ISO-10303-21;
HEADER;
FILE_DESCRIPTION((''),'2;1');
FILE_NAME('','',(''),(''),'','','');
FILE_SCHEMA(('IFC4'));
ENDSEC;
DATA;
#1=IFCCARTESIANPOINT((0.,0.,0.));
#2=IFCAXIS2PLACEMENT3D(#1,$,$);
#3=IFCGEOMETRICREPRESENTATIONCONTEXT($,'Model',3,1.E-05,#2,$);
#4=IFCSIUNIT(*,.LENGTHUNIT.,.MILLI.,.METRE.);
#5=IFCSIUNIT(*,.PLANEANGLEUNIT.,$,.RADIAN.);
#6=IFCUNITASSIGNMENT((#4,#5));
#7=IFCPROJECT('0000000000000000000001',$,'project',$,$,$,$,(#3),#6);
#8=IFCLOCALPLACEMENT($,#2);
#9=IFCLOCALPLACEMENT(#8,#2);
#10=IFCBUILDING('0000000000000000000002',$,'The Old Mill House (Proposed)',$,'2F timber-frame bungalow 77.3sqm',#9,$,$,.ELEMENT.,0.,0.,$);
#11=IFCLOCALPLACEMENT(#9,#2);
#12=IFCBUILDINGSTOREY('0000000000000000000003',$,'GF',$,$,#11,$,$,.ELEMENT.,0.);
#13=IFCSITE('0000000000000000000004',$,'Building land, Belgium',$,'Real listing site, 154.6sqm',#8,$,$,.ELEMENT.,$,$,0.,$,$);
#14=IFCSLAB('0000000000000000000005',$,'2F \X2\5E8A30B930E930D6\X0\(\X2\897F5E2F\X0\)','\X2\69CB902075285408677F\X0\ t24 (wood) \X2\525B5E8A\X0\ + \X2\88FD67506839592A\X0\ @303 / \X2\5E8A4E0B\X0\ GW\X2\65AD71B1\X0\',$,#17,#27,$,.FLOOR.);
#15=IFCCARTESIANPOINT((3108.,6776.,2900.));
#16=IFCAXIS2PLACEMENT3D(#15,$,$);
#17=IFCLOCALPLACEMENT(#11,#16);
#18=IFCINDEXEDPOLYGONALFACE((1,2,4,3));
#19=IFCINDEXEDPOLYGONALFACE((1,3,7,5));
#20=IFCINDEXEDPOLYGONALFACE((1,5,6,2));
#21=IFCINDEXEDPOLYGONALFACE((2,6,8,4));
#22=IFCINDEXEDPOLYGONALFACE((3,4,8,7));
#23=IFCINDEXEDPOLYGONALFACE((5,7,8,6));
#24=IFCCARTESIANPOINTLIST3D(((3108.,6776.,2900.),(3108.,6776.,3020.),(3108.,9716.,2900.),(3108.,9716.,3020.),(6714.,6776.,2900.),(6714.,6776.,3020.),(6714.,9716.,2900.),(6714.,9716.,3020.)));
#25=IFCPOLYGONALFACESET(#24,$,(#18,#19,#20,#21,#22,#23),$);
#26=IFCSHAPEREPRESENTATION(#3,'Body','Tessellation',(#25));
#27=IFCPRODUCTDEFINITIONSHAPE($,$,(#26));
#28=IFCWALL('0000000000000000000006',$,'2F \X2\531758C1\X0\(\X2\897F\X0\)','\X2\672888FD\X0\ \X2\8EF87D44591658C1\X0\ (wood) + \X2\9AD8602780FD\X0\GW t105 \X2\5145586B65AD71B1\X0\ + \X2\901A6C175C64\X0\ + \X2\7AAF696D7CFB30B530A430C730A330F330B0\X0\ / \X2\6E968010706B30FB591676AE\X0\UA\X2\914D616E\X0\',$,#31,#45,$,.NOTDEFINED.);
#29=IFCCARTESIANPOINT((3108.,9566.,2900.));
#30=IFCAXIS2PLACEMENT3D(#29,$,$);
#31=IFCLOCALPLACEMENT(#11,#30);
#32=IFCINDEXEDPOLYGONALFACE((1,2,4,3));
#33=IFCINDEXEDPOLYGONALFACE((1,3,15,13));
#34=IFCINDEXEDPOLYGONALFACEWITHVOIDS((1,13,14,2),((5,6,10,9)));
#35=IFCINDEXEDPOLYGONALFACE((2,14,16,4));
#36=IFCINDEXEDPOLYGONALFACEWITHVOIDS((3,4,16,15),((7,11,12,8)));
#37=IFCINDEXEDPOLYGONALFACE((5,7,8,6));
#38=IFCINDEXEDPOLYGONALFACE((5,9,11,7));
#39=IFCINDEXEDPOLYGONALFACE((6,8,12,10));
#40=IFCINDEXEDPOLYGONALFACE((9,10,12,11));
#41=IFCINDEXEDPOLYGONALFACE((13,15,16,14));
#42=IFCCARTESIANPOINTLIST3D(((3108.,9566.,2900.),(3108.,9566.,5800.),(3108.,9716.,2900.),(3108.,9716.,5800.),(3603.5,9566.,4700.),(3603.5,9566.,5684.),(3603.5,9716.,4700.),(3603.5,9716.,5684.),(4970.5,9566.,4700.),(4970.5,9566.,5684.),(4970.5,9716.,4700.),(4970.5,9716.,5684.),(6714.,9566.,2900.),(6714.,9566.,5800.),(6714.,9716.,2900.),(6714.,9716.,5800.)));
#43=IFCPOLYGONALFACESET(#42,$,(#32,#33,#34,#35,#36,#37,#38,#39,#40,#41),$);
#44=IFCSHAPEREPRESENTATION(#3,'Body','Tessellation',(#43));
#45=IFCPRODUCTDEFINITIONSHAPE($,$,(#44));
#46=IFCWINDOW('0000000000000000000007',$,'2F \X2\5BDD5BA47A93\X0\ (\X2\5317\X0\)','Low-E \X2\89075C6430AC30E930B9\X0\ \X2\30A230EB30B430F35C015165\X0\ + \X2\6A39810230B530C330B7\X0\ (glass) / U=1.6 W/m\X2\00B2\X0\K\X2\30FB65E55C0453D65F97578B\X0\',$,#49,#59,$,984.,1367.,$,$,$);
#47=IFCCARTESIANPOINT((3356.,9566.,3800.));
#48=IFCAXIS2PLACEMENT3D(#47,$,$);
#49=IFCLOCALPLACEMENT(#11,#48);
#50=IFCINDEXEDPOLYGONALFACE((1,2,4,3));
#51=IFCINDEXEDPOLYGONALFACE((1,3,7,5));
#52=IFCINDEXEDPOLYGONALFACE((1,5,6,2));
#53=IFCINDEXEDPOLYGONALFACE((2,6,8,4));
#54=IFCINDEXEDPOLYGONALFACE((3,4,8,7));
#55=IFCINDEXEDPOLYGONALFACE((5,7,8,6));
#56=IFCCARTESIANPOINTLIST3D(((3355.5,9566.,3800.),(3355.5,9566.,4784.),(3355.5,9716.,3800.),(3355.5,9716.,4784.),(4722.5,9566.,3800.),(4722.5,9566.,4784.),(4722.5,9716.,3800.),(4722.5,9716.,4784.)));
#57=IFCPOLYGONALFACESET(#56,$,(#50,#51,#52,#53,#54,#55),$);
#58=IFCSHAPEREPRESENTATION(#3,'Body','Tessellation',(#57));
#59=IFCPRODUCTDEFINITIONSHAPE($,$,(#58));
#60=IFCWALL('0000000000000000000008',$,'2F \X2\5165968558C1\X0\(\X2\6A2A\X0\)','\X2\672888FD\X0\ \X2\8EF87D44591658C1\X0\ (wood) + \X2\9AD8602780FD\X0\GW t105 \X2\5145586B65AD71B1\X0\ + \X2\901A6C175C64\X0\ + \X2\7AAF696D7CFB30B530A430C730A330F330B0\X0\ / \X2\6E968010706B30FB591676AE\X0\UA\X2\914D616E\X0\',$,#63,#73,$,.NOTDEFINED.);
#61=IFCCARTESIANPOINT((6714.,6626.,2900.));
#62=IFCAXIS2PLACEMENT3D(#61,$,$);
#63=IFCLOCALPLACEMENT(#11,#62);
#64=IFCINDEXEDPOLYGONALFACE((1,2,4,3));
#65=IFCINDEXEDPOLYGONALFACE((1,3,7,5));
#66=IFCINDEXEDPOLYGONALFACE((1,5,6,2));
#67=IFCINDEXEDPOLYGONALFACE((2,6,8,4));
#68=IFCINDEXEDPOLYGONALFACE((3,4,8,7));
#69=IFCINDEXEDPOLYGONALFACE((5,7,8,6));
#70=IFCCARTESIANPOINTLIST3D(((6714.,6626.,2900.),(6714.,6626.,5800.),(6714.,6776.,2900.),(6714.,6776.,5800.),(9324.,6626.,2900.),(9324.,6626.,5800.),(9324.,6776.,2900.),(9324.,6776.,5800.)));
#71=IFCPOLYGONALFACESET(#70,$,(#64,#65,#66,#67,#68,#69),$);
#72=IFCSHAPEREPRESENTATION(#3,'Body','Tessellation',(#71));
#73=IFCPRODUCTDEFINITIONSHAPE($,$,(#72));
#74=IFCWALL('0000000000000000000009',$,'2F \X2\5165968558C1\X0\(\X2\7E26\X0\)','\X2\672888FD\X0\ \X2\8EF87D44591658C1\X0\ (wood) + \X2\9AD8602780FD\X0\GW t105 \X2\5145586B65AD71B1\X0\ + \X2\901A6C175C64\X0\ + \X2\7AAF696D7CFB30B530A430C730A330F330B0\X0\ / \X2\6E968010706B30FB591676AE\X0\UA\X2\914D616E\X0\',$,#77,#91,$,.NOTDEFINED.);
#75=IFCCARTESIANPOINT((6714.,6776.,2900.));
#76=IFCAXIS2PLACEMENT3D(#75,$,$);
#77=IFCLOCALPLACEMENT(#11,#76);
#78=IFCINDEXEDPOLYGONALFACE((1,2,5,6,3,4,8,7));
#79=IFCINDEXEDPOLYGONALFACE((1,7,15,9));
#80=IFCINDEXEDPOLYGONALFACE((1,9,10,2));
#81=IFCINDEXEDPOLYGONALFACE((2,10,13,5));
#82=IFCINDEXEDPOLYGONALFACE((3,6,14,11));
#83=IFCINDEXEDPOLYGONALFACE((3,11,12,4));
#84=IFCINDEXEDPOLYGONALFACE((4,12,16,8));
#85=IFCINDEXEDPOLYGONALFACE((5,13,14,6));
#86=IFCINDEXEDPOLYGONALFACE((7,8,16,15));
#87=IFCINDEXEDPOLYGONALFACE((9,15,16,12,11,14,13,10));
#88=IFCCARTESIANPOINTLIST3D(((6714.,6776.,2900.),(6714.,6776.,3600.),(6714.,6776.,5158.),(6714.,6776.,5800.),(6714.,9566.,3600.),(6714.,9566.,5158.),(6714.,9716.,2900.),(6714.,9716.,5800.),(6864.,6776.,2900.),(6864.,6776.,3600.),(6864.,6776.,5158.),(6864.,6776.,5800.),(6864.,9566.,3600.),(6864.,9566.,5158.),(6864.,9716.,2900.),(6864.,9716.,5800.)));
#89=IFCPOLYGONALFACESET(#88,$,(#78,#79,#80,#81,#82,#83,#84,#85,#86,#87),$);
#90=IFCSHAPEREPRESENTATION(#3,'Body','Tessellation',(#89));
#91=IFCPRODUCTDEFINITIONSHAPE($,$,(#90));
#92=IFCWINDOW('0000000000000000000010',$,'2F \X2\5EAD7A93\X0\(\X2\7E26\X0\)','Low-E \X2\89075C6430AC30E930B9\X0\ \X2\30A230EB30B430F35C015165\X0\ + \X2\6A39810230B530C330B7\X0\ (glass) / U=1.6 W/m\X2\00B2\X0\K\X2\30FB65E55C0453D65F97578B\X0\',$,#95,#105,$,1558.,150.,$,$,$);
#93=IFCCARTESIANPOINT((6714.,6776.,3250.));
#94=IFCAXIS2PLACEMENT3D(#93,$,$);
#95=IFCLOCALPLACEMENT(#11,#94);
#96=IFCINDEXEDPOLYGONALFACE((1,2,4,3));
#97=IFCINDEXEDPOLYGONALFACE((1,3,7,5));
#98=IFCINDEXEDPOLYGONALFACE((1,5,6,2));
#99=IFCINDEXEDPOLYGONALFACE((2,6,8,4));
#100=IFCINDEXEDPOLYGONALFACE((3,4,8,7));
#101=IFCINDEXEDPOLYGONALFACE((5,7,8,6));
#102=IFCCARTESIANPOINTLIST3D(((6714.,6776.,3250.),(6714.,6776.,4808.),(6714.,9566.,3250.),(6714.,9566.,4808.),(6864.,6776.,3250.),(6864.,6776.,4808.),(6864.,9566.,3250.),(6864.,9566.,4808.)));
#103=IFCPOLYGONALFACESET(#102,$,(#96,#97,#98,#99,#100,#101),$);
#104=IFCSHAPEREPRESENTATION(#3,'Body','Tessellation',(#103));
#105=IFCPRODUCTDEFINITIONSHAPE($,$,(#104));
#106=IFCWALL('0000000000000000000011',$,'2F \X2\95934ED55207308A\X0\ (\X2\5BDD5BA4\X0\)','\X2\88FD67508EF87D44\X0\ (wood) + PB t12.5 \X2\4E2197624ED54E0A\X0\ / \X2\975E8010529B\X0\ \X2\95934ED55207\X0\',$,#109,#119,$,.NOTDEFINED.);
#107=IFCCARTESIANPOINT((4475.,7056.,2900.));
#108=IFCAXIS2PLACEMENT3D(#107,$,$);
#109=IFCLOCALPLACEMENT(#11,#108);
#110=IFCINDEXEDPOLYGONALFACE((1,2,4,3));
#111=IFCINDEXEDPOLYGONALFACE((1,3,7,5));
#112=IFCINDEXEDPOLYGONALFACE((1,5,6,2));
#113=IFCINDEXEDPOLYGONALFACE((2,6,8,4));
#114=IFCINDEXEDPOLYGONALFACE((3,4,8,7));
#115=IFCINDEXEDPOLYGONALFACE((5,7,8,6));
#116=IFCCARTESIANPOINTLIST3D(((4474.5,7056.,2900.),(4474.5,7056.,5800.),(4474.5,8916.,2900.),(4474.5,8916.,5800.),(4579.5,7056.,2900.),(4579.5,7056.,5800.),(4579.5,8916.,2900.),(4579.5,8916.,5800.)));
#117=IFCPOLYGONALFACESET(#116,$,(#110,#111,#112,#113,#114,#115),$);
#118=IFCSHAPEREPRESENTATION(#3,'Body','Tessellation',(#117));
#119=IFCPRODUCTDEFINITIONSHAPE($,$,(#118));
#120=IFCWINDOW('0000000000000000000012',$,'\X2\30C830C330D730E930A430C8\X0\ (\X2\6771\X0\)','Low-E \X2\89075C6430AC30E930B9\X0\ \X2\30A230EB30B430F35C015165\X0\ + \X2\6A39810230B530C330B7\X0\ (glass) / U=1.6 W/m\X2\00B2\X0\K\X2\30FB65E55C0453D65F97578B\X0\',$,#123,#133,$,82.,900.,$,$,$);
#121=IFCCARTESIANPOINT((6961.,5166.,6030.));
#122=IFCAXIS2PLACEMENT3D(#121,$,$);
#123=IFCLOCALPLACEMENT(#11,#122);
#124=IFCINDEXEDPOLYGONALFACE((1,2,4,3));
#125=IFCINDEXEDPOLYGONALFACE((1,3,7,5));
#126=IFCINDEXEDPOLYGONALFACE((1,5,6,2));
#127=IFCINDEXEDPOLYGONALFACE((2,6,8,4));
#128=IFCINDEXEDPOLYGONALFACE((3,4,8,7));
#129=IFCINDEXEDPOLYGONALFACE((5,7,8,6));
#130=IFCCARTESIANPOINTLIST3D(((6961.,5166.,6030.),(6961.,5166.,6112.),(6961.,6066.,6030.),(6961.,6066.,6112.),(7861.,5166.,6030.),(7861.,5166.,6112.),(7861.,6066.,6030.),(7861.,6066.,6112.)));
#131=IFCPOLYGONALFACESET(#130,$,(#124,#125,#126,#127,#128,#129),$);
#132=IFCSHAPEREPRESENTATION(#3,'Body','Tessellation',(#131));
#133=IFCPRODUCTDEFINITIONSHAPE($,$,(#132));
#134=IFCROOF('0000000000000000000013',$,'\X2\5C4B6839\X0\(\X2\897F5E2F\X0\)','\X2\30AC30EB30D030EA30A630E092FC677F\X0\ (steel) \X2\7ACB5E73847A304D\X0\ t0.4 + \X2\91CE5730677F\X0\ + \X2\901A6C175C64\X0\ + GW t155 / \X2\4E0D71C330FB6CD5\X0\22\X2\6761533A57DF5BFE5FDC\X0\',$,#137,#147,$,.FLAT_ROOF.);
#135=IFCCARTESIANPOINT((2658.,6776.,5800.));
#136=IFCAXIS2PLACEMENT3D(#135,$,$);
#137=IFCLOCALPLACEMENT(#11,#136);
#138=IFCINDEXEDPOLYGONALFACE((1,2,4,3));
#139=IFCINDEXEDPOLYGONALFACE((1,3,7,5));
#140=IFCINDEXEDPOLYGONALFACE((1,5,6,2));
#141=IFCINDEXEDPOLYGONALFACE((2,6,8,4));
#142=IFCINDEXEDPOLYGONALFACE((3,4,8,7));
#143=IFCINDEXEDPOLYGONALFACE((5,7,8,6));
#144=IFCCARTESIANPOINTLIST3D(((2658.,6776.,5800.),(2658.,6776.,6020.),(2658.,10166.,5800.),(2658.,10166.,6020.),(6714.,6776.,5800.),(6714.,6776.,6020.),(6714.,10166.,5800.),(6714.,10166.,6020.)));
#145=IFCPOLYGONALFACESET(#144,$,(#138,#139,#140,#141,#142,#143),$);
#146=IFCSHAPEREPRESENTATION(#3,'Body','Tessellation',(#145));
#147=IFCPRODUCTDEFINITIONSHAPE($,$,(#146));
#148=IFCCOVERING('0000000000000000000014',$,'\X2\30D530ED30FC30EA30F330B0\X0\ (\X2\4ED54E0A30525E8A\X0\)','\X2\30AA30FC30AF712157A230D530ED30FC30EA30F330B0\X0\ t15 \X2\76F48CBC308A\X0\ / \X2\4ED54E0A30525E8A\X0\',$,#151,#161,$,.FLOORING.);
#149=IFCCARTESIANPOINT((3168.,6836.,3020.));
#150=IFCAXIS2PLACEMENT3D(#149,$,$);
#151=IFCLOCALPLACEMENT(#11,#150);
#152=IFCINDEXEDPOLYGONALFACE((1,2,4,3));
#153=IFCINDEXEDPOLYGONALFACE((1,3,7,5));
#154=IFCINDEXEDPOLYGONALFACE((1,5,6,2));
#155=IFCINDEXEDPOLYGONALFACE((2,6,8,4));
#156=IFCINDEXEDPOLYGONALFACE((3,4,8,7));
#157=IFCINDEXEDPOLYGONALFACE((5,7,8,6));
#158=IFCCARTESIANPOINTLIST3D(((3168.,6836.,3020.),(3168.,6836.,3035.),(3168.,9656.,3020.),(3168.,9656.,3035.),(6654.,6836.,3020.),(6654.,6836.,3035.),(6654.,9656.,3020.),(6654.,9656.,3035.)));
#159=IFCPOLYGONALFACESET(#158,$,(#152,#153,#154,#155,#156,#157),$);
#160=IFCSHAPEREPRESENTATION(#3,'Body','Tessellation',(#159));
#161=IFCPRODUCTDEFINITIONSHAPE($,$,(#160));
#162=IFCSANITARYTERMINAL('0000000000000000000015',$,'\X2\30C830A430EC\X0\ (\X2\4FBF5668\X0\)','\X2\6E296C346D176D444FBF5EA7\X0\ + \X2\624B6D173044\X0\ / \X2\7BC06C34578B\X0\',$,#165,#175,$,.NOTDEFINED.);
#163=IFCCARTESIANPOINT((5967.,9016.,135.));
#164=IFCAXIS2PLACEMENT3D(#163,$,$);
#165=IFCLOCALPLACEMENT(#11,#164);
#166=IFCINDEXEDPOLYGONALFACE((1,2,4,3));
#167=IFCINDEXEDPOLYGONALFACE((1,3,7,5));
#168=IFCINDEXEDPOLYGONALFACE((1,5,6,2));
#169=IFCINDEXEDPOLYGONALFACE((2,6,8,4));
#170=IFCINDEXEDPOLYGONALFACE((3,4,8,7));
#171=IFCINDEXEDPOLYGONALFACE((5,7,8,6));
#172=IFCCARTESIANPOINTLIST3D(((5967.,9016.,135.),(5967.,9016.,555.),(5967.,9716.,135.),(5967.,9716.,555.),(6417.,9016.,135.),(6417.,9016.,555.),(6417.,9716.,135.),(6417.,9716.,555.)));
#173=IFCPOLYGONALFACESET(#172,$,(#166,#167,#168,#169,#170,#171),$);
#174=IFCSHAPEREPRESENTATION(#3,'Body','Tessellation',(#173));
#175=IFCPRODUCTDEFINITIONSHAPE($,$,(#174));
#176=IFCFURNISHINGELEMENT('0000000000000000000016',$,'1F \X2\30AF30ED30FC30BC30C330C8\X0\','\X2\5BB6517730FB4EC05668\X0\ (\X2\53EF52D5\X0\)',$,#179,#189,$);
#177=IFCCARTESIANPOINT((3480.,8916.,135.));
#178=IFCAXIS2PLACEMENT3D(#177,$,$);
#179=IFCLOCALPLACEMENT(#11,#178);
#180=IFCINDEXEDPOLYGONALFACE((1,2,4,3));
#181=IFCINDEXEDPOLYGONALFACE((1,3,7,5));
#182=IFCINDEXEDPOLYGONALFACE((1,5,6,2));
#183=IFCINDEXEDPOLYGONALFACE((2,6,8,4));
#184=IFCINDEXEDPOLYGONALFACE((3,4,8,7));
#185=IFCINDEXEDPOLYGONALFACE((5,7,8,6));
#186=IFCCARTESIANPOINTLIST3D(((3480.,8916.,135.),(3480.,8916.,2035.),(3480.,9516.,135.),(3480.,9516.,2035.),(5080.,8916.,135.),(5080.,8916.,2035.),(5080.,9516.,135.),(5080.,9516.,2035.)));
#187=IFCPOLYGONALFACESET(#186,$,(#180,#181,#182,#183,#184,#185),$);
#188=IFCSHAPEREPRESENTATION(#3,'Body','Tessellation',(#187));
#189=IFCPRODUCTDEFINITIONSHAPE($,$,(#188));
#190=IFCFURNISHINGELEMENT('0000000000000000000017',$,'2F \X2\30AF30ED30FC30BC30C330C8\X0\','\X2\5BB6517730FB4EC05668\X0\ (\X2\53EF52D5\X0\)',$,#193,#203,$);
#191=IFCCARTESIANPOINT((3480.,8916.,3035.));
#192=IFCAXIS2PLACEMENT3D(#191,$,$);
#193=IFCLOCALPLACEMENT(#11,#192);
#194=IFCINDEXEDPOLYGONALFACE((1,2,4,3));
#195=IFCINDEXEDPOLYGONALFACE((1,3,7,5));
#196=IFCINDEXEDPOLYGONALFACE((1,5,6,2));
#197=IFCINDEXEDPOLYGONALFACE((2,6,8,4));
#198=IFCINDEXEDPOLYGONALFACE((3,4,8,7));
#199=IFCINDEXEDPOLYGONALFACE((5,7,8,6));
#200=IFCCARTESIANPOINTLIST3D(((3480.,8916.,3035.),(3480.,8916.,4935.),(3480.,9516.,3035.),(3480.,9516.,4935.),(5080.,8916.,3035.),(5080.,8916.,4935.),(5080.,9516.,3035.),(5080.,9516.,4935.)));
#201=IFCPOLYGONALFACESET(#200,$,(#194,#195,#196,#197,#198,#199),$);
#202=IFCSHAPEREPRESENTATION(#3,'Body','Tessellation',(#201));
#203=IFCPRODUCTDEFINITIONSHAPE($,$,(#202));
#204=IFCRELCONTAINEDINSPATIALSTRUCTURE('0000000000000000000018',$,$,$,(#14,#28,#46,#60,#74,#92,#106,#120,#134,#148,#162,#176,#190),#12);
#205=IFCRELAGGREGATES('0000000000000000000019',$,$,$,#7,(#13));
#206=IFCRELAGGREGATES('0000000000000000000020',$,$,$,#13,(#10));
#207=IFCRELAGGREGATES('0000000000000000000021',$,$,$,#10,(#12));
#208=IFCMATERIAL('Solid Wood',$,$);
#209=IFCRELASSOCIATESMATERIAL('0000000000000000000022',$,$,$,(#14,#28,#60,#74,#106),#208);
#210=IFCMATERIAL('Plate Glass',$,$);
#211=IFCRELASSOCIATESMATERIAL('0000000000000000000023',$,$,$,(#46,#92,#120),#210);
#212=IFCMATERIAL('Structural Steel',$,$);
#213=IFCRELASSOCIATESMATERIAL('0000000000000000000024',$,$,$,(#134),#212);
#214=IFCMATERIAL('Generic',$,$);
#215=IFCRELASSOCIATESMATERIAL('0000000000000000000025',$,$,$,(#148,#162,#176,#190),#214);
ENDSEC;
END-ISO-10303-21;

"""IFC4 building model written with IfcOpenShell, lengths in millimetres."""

from ifc_helpers import new_model, si_unit, frame, frame_2d, origin, place, context, project, spatial, rectangle, extrude, material, element, fill, save


model = new_model("IFC4")

# Units and contexts
model_context = context("Model", 3, precision=1e-05, world=origin())
ifc_project = project(units=[si_unit("LENGTHUNIT", "METRE", prefix="MILLI"), si_unit("PLANEANGLEUNIT", "RADIAN")], contexts=[model_context])

# Site, building, storey
site_placement = place(None, origin())
site = spatial("IfcSite", under=ifc_project, at=site_placement, Name="Building land, Belgium", ObjectType="Real listing site, 154.6sqm", CompositionType="ELEMENT", RefElevation=0.0)
building_placement = place(site_placement, origin())
building = spatial("IfcBuilding", under=site, at=building_placement, Name="The Old Mill House (Proposed)", ObjectType="2F timber-frame bungalow 77.3sqm", CompositionType="ELEMENT", ElevationOfRefHeight=0.0, ElevationOfTerrain=0.0)
storey_placement = place(building_placement, origin())
storey = spatial("IfcBuildingStorey", under=building, at=storey_placement, Name="GF", CompositionType="ELEMENT", Elevation=0.0)

# Slab
ifc_material_1 = material(Name="Solid Wood")
slab_placement = place(storey_placement, frame((3108.0, 6776.0, 2900.0)))
element("IfcSlab", 1, at=slab_placement, inside=storey, material=ifc_material_1, Name="2F 床スラブ(西帯)", Description="構造用合板 t24 (wood) 剛床 + 製材根太 @303 / 床下 GW断熱", PredefinedType="FLOOR", context=model_context, shape_type="SweptSolid", body=[
    extrude(rectangle(XDim=3606.0, YDim=2940.0, at=frame_2d((1803.0, 1470.0))), frame((3108.0, 6776.0, 2900.0)), (0.0, 0.0, 1.0), 120.0),
])

# Wall, opening, window
wall_1_placement = place(storey_placement, frame((3108.0, 9566.0, 2900.0)))
wall_1 = element("IfcWall", 2, at=wall_1_placement, inside=storey, material=ifc_material_1, Name="2F 北壁(西)", Description="木製 軸組外壁 (wood) + 高性能GW t105 充填断熱 + 通気層 + 窯業系サイディング / 準耐火・外皮UA配慮", PredefinedType="NOTDEFINED", context=model_context, shape_type="SweptSolid", body=[
    extrude(rectangle(XDim=3606.0, YDim=150.0, at=frame_2d((1803.0, 75.0))), frame((3108.0, 9566.0, 2900.0)), (0.0, 0.0, 1.0), 2900.0),
])
opening_1_placement = place(storey_placement, frame((3356.0, 9566.0, 3800.0)))
opening_1 = element("IfcOpeningElement", 3, at=opening_1_placement, cuts=wall_1, PredefinedType="NOTDEFINED", context=model_context, shape_type="SweptSolid", body=[
    extrude(rectangle(XDim=1367.0, YDim=150.0, at=frame_2d((683.0, 75.0))), frame((3356.0, 9566.0, 3800.0)), (0.0, 0.0, 1.0), 984.0),
])
ifc_material_2 = material(Name="Plate Glass")
window_1_placement = place(storey_placement, frame((3356.0, 9566.0, 3800.0)))
window_1 = element("IfcWindow", 4, at=window_1_placement, inside=storey, material=ifc_material_2, Name="2F 寝室窓 (北)", Description="Low-E 複層ガラス アルゴン封入 + 樹脂サッシ (glass) / U=1.6 W/m²K・日射取得型", OverallHeight=984.0, OverallWidth=1367.0, context=model_context, shape_type="SweptSolid", body=[
    extrude(rectangle(XDim=1367.0, YDim=150.0, at=frame_2d((683.0, 75.0))), frame((3356.0, 9566.0, 3800.0)), (0.0, 0.0, 1.0), 984.0),
])
fill(opening_1, window_1)

# Wall
wall_2_placement = place(storey_placement, frame((6714.0, 6626.0, 2900.0)))
element("IfcWall", 5, at=wall_2_placement, inside=storey, material=ifc_material_1, Name="2F 入隅壁(横)", Description="木製 軸組外壁 (wood) + 高性能GW t105 充填断熱 + 通気層 + 窯業系サイディング / 準耐火・外皮UA配慮", PredefinedType="NOTDEFINED", context=model_context, shape_type="SweptSolid", body=[
    extrude(rectangle(XDim=2610.0, YDim=150.0, at=frame_2d((1305.0, 75.0))), frame((6714.0, 6626.0, 2900.0)), (0.0, 0.0, 1.0), 2900.0),
])

# Wall, opening, window
wall_3_placement = place(storey_placement, frame((6714.0, 6776.0, 2900.0)))
wall_3 = element("IfcWall", 6, at=wall_3_placement, inside=storey, material=ifc_material_1, Name="2F 入隅壁(縦)", Description="木製 軸組外壁 (wood) + 高性能GW t105 充填断熱 + 通気層 + 窯業系サイディング / 準耐火・外皮UA配慮", PredefinedType="NOTDEFINED", context=model_context, shape_type="SweptSolid", body=[
    extrude(rectangle(XDim=150.0, YDim=2940.0, at=frame_2d((75.0, 1470.0))), frame((6714.0, 6776.0, 2900.0)), (0.0, 0.0, 1.0), 2900.0),
])
opening_2_placement = place(storey_placement, frame((6714.0, 6776.0, 3250.0)))
opening_2 = element("IfcOpeningElement", 7, at=opening_2_placement, cuts=wall_3, PredefinedType="NOTDEFINED", context=model_context, shape_type="SweptSolid", body=[
    extrude(rectangle(XDim=150.0, YDim=2790.0, at=frame_2d((75.0, 1395.0))), frame((6714.0, 6776.0, 3250.0)), (0.0, 0.0, 1.0), 1558.0),
])
window_2_placement = place(storey_placement, frame((6714.0, 6776.0, 3250.0)))
window_2 = element("IfcWindow", 8, at=window_2_placement, inside=storey, material=ifc_material_2, Name="2F 庭窓(縦)", Description="Low-E 複層ガラス アルゴン封入 + 樹脂サッシ (glass) / U=1.6 W/m²K・日射取得型", OverallHeight=1558.0, OverallWidth=150.0, context=model_context, shape_type="SweptSolid", body=[
    extrude(rectangle(XDim=150.0, YDim=2790.0, at=frame_2d((75.0, 1395.0))), frame((6714.0, 6776.0, 3250.0)), (0.0, 0.0, 1.0), 1558.0),
])
fill(opening_2, window_2)

# Wall
wall_4_placement = place(storey_placement, frame((4475.0, 7056.0, 2900.0)))
element("IfcWall", 9, at=wall_4_placement, inside=storey, material=ifc_material_1, Name="2F 間仕切り (寝室)", Description="製材軸組 (wood) + PB t12.5 両面仕上 / 非耐力 間仕切", PredefinedType="NOTDEFINED", context=model_context, shape_type="SweptSolid", body=[
    extrude(rectangle(XDim=105.0, YDim=1860.0, at=frame_2d((52.0, 930.0))), frame((4475.0, 7056.0, 2900.0)), (0.0, 0.0, 1.0), 2900.0),
])

# Window
window_3_placement = place(storey_placement, frame((6961.0, 5166.0, 6030.0)))
element("IfcWindow", 10, at=window_3_placement, inside=storey, material=ifc_material_2, Name="トップライト (東)", Description="Low-E 複層ガラス アルゴン封入 + 樹脂サッシ (glass) / U=1.6 W/m²K・日射取得型", OverallHeight=82.0, OverallWidth=900.0, context=model_context, shape_type="SweptSolid", body=[
    extrude(rectangle(XDim=900.0, YDim=900.0, at=frame_2d((450.0, 450.0))), frame((6961.0, 5166.0, 6030.0)), (0.0, 0.0, 1.0), 82.0),
])

# Roof
ifc_material_3 = material(Name="Structural Steel")
for number, where, name in (
    (11, (2658.0, 6776.0, 5800.0), "屋根(西帯)"),
):
    element("IfcRoof", number, at=place(storey_placement, frame(where)), inside=storey, material=ifc_material_3, Name=name, Description="ガルバリウム鋼板 (steel) 立平葺き t0.4 + 野地板 + 通気層 + GW t155 / 不燃・法22条区域対応", PredefinedType="FLAT_ROOF", context=model_context, shape_type="SweptSolid", body=[
        extrude(rectangle(XDim=4056.0, YDim=3390.0, at=frame_2d((2028.0, 1695.0))), frame((2658.0, 6776.0, 5800.0)), (0.0, 0.0, 1.0), 220.0),
    ])

# Covering
ifc_material_4 = material(Name="Generic")
covering_placement = place(storey_placement, frame((3168.0, 6836.0, 3020.0)))
element("IfcCovering", 12, at=covering_placement, inside=storey, material=ifc_material_4, Name="フローリング (仕上げ床)", Description="オーク無垢フローリング t15 直貼り / 仕上げ床", PredefinedType="FLOORING", context=model_context, shape_type="SweptSolid", body=[
    extrude(rectangle(XDim=3486.0, YDim=2820.0, at=frame_2d((1743.0, 1410.0))), frame((3168.0, 6836.0, 3020.0)), (0.0, 0.0, 1.0), 15.0),
])

# Sanitary terminal
sanitary_terminal_placement = place(storey_placement, frame((5967.0, 9016.0, 135.0)))
element("IfcSanitaryTerminal", 13, at=sanitary_terminal_placement, inside=storey, material=ifc_material_4, Name="トイレ (便器)", Description="温水洗浄便座 + 手洗い / 節水型", PredefinedType="NOTDEFINED", context=model_context, shape_type="SweptSolid", body=[
    extrude(rectangle(XDim=450.0, YDim=700.0, at=frame_2d((225.0, 350.0))), frame((5967.0, 9016.0, 135.0)), (0.0, 0.0, 1.0), 420.0),
])

# Furnishing elements
furnishing_1_placement = place(storey_placement, frame((3480.0, 8916.0, 135.0)))
element("IfcFurnishingElement", 14, at=furnishing_1_placement, inside=storey, material=ifc_material_4, Name="1F クローゼット", Description="家具・什器 (可動)", context=model_context, shape_type="SweptSolid", body=[
    extrude(rectangle(XDim=1600.0, YDim=600.0, at=frame_2d((800.0, 300.0))), frame((3480.0, 8916.0, 135.0)), (0.0, 0.0, 1.0), 1900.0),
])
furnishing_2_placement = place(storey_placement, frame((3480.0, 8916.0, 3035.0)))
element("IfcFurnishingElement", 15, at=furnishing_2_placement, inside=storey, material=ifc_material_4, Name="2F クローゼット", Description="家具・什器 (可動)", context=model_context, shape_type="SweptSolid", body=[
    extrude(rectangle(XDim=1600.0, YDim=600.0, at=frame_2d((800.0, 300.0))), frame((3480.0, 8916.0, 3035.0)), (0.0, 0.0, 1.0), 1900.0),
])

save(model, "model.ifc")
